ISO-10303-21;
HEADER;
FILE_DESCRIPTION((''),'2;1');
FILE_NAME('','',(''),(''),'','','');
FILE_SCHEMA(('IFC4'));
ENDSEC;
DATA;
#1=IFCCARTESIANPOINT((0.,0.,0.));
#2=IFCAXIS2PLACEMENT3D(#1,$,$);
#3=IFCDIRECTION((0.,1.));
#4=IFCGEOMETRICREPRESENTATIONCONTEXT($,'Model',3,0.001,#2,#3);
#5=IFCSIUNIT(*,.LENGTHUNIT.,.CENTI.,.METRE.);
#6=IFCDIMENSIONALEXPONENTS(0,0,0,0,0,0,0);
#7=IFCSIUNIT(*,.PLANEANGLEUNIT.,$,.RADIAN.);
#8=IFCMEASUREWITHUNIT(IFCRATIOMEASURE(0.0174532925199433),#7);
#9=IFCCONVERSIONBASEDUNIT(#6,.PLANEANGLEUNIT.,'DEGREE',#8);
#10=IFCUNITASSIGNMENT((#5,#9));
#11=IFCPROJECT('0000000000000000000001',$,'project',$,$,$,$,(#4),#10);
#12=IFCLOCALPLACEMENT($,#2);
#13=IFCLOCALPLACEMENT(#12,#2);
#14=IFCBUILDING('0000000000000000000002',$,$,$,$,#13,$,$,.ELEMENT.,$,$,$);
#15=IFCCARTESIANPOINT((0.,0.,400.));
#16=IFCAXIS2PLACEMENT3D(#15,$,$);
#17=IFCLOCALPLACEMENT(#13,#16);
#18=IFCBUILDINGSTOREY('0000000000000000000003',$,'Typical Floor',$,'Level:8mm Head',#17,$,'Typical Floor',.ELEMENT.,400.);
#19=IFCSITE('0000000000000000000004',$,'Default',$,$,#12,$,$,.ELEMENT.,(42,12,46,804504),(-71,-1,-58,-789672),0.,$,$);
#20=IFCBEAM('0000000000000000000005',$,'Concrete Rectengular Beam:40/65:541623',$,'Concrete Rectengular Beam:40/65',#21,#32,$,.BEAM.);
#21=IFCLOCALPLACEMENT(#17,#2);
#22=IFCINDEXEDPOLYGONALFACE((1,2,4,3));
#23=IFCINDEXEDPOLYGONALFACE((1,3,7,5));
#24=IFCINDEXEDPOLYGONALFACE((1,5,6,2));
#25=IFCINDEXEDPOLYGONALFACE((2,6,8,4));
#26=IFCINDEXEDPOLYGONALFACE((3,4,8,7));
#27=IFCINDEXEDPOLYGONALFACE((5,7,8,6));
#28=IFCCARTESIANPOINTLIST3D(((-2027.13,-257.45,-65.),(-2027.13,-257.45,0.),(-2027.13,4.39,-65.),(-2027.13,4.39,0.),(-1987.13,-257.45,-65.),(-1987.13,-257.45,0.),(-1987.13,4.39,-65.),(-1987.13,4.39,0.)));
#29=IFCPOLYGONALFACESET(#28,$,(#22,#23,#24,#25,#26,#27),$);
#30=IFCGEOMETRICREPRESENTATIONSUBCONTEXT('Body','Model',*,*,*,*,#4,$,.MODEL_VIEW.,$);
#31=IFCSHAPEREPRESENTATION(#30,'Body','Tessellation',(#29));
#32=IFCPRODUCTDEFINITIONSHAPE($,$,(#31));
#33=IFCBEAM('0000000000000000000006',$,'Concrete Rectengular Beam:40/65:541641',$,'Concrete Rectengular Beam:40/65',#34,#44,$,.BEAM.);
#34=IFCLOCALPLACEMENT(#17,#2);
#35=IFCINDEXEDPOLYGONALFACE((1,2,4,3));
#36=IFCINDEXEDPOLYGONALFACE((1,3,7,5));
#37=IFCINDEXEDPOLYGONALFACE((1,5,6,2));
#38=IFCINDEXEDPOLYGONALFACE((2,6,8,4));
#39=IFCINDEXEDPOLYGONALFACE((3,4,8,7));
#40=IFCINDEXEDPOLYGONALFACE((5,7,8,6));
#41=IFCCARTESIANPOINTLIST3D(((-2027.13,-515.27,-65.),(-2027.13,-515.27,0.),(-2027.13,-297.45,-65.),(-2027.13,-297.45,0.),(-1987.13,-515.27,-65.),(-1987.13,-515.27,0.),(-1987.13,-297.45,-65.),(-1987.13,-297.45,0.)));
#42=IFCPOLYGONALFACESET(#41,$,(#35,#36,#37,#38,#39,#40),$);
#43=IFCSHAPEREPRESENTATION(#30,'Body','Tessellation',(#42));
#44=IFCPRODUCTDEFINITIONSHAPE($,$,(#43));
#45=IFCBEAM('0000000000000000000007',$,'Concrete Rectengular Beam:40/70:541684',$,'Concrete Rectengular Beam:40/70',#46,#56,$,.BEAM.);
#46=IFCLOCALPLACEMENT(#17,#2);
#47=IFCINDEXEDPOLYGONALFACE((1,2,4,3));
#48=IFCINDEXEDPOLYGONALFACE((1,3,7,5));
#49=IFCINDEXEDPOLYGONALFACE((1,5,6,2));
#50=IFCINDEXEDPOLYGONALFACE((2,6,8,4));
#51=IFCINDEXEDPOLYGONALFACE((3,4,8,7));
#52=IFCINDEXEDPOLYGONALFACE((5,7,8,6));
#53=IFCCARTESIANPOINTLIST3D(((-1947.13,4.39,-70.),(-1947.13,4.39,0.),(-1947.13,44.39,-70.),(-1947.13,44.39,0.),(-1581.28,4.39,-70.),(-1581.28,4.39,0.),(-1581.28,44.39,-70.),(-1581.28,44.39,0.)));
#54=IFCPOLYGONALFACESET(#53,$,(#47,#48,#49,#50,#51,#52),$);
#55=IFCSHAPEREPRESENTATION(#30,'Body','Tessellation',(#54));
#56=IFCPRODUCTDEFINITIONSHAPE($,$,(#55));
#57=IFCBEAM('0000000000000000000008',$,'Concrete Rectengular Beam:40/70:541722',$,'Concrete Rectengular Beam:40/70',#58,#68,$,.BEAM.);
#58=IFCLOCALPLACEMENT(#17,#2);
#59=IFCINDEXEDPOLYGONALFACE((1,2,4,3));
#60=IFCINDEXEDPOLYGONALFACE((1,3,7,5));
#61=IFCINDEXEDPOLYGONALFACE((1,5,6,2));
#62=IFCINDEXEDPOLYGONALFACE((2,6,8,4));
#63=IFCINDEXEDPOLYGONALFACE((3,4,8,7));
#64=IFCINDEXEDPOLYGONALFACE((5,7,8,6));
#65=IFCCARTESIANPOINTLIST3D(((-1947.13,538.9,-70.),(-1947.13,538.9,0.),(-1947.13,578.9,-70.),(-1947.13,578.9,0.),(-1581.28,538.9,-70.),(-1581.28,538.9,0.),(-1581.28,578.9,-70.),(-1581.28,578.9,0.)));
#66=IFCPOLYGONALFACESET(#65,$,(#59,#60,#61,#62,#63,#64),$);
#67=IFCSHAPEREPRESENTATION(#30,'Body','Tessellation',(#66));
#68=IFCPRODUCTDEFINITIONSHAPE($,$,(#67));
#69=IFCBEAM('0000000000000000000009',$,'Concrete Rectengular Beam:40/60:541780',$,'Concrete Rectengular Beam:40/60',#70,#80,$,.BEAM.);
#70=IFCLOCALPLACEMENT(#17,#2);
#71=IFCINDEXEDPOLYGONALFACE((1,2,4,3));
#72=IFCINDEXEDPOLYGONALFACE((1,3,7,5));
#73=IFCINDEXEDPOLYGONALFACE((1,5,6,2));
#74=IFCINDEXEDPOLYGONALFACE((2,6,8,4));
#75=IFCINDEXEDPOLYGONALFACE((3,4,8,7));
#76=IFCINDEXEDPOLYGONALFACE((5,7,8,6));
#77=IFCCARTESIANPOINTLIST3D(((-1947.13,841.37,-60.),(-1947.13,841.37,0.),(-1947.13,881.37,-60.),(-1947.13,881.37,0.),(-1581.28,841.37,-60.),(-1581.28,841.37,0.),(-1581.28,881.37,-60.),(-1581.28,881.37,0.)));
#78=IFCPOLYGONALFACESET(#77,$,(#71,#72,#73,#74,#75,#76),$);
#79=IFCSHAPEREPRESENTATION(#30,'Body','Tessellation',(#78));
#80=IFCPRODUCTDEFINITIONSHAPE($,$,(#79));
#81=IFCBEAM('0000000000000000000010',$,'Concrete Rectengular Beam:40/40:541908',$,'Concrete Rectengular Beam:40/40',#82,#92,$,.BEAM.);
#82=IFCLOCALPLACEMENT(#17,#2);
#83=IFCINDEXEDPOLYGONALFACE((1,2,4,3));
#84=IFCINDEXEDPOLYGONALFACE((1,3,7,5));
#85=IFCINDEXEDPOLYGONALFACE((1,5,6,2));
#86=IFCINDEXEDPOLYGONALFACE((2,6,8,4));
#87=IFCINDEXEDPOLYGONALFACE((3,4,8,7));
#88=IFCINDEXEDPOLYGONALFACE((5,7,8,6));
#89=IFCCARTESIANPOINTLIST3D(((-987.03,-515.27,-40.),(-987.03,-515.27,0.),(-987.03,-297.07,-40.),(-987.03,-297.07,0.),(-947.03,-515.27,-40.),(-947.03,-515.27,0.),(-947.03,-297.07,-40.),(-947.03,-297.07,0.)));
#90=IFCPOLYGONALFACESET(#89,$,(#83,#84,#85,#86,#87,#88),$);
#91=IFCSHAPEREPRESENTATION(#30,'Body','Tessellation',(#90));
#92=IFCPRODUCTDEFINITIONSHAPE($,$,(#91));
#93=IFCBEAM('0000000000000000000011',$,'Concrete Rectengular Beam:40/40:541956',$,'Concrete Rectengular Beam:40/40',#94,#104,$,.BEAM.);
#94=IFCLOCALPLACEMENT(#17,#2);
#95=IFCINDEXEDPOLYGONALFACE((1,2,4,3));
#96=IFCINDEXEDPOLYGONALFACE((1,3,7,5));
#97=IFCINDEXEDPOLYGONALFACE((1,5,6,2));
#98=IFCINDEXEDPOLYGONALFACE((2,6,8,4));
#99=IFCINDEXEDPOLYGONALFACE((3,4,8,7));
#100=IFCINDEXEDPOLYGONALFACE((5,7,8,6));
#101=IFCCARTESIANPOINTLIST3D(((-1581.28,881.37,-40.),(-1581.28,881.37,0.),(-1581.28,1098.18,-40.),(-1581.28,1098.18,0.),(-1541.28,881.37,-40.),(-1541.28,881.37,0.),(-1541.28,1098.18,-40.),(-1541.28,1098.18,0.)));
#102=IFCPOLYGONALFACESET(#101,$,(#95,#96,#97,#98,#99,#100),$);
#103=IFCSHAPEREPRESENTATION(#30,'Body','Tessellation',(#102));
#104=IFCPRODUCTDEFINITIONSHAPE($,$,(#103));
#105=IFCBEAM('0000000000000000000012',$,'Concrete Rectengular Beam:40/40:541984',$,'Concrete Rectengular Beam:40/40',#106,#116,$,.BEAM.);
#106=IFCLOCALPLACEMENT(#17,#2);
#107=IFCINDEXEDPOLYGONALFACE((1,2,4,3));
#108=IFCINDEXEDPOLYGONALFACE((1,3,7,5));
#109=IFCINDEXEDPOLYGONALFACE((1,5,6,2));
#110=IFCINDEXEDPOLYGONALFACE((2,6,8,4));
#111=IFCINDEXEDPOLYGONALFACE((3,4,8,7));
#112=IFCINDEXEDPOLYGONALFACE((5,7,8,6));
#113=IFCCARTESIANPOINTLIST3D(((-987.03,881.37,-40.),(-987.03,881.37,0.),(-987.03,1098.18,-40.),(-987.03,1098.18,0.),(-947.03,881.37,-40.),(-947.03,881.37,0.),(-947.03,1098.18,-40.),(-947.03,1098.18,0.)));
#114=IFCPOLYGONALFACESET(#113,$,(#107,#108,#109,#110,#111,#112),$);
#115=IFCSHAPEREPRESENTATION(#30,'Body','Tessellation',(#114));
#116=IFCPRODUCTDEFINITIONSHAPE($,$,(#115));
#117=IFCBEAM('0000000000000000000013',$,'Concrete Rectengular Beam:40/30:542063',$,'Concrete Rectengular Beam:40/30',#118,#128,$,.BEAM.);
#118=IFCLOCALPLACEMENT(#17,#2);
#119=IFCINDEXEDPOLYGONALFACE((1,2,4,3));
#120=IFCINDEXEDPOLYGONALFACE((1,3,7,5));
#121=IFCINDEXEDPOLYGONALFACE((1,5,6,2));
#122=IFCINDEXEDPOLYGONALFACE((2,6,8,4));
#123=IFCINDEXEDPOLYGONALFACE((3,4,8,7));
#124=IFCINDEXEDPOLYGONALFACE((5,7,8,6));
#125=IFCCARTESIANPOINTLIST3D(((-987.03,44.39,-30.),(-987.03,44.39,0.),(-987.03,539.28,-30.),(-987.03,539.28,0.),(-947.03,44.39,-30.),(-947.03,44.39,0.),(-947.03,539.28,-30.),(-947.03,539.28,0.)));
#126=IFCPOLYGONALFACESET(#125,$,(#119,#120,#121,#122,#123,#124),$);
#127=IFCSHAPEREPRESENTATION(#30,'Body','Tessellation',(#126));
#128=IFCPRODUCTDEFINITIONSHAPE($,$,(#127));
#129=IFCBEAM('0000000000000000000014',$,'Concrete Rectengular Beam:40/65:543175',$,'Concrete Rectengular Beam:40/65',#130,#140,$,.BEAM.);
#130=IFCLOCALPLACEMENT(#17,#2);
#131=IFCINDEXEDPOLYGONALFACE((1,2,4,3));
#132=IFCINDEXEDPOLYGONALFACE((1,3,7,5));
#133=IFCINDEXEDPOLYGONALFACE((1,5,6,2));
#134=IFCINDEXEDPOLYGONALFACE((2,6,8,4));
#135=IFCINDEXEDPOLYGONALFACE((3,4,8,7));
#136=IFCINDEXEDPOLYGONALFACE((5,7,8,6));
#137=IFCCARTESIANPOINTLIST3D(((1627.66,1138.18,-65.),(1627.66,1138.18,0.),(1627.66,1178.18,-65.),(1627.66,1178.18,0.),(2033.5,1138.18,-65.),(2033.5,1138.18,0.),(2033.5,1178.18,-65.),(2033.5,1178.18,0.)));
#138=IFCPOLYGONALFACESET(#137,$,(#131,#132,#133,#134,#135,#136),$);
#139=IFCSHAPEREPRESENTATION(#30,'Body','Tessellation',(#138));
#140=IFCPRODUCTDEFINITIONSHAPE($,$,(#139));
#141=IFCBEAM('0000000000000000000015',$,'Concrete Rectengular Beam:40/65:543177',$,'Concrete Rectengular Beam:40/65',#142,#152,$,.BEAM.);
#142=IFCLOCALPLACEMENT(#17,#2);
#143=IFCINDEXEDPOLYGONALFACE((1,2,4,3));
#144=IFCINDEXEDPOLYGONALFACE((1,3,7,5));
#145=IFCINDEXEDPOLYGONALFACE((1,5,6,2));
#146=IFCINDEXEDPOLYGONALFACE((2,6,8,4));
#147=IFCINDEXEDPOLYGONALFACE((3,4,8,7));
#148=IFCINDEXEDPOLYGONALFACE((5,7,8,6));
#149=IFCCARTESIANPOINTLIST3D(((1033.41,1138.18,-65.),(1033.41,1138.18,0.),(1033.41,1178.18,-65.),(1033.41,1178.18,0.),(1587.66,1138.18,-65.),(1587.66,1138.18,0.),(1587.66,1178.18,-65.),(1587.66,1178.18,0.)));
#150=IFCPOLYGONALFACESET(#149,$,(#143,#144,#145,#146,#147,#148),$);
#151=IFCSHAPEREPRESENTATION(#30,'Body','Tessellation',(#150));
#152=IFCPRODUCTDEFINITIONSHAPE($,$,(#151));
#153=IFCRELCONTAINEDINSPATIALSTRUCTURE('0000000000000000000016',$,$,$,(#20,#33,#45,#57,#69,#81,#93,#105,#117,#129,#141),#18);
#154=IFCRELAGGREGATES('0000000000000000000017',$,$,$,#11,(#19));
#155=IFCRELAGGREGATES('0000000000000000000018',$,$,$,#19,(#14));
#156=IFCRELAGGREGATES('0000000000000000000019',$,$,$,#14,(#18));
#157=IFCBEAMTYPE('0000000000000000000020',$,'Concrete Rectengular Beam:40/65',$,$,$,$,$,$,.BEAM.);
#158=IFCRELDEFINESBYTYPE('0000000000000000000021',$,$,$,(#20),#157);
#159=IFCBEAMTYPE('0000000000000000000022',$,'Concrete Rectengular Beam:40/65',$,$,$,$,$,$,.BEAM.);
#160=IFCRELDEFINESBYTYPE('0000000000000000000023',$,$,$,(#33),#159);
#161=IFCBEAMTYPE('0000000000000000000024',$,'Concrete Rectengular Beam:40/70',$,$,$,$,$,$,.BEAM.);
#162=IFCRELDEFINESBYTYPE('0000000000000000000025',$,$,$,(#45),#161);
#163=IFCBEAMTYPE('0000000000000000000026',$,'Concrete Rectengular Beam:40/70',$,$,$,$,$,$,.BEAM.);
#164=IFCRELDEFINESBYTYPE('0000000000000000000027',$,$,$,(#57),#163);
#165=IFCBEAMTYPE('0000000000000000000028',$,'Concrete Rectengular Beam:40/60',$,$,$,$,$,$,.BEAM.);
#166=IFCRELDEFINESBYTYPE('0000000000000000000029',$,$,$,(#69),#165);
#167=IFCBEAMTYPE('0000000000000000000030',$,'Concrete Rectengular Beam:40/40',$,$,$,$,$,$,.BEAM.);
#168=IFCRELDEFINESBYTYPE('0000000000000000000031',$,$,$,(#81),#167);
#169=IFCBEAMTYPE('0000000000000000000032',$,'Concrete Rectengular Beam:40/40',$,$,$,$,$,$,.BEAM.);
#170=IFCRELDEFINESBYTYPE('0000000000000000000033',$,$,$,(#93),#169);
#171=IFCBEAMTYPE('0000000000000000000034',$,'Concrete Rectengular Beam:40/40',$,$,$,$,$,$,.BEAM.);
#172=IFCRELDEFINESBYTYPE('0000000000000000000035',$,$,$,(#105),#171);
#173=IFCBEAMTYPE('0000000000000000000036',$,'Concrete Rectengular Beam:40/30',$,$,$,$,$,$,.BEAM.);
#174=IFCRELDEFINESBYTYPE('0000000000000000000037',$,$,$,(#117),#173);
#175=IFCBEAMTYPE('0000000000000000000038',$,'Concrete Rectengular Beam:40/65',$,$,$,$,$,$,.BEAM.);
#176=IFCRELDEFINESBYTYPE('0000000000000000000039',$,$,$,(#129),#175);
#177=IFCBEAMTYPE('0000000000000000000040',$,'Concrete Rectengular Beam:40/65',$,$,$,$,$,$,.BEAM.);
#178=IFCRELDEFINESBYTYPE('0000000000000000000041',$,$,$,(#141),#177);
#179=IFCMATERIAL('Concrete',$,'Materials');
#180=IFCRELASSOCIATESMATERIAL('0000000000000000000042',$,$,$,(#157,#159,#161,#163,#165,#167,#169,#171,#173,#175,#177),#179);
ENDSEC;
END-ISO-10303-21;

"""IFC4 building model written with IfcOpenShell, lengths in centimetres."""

from ifc_helpers import new_model, entity, si_unit, converted_unit, direction, frame, origin, place, context, subcontext, project, spatial, indexed_curve, outline, extrude, source, transform, mapped, material, type_object, type_shapes, element, save


model = new_model("IFC4")

# Units and contexts
model_context = context("Model", 3, precision=0.001, world=origin(), true_north=direction((0.0, 1.0)))
body_context = subcontext(model_context, "Body", "Model", "MODEL_VIEW")
ifc_project = project(units=[si_unit("LENGTHUNIT", "METRE", prefix="CENTI"), converted_unit("PLANEANGLEUNIT", "DEGREE", entity("IfcRatioMeasure", 0.0174532925199433), si_unit("PLANEANGLEUNIT", "RADIAN"), dimensions=[0, 0, 0, 0, 0, 0, 0])], contexts=[model_context])

# Site, building, storey
site_placement = place(None, origin())
site = spatial("IfcSite", under=ifc_project, at=site_placement, Name="Default", CompositionType="ELEMENT", RefLatitude=(42, 12, 46, 804504), RefLongitude=(-71, -1, -58, -789672), RefElevation=0.0)
building_placement = place(site_placement, origin())
building = spatial("IfcBuilding", under=site, at=building_placement, CompositionType="ELEMENT")
storey_placement = place(building_placement, frame((0.0, 0.0, 400.0)))
storey = spatial("IfcBuildingStorey", under=building, at=storey_placement, Name="Typical Floor", ObjectType="Level:8mm Head", LongName="Typical Floor", CompositionType="ELEMENT", Elevation=400.0)

# Beams
ifc_material = material(Name="Concrete", Category="Materials")
beam_type_1 = type_object("IfcBeamType", Name="Concrete Rectengular Beam:40/65", PredefinedType="BEAM", material=ifc_material)
shared_shape_1 = source(origin(), body_context, "Body", "SweptSolid", [
    extrude(outline(indexed_curve([(-20.0, -32.5), (20.0, -32.5), (20.0, 32.5), (-20.0, 32.5), (-20.0, -32.5)], self_intersect=False)), frame((-2007.13, 4.39, 367.5), z_axis=(0.0, -1.0, 0.0), x_axis=(-1.0, 0.0, 0.0)), (0.0, 0.0, 1.0), 261.84),
])
type_shapes(beam_type_1, [shared_shape_1])
beam_1_placement = place(storey_placement, frame((0.0, 0.0, -400.0)))
element("IfcBeam", 1, at=beam_1_placement, inside=storey, type_object=beam_type_1, Name="Concrete Rectengular Beam:40/65:541623", ObjectType="Concrete Rectengular Beam:40/65", PredefinedType="BEAM", context=body_context, shape_type="MappedRepresentation", body=[
    mapped(shared_shape_1, transform((0.0, 0.0, 0.0), scale=1.0)),
])
beam_type_2 = type_object("IfcBeamType", Name="Concrete Rectengular Beam:40/65", PredefinedType="BEAM", material=ifc_material)
shared_shape_2 = source(origin(), body_context, "Body", "SweptSolid", [
    extrude(outline(indexed_curve([(-20.0, -32.5), (20.0, -32.5), (20.0, 32.5), (-20.0, 32.5), (-20.0, -32.5)], self_intersect=False)), frame((-2007.13, -297.45, 367.5), z_axis=(0.0, -1.0, 0.0), x_axis=(-1.0, 0.0, 0.0)), (0.0, 0.0, 1.0), 217.82),
])
type_shapes(beam_type_2, [shared_shape_2])
beam_2_placement = place(storey_placement, frame((0.0, 0.0, -400.0)))
element("IfcBeam", 2, at=beam_2_placement, inside=storey, type_object=beam_type_2, Name="Concrete Rectengular Beam:40/65:541641", ObjectType="Concrete Rectengular Beam:40/65", PredefinedType="BEAM", context=body_context, shape_type="MappedRepresentation", body=[
    mapped(shared_shape_2, transform((0.0, 0.0, 0.0), scale=1.0)),
])
beam_type_3 = type_object("IfcBeamType", Name="Concrete Rectengular Beam:40/70", PredefinedType="BEAM", material=ifc_material)
shared_shape_3 = source(origin(), body_context, "Body", "SweptSolid", [
    extrude(outline(indexed_curve([(-35.0, -20.0), (35.0, -20.0), (35.0, 20.0), (-35.0, 20.0), (-35.0, -20.0)], self_intersect=False)), frame((-1947.13, 24.39, 365.0), z_axis=(1.0, 0.0, 0.0), x_axis=(0.0, 0.0, -1.0)), (0.0, 0.0, 1.0), 365.84),
])
type_shapes(beam_type_3, [shared_shape_3])
beam_3_placement = place(storey_placement, frame((0.0, 0.0, -400.0)))
element("IfcBeam", 3, at=beam_3_placement, inside=storey, type_object=beam_type_3, Name="Concrete Rectengular Beam:40/70:541684", ObjectType="Concrete Rectengular Beam:40/70", PredefinedType="BEAM", context=body_context, shape_type="MappedRepresentation", body=[
    mapped(shared_shape_3, transform((0.0, 0.0, 0.0), scale=1.0)),
])
beam_type_4 = type_object("IfcBeamType", Name="Concrete Rectengular Beam:40/70", PredefinedType="BEAM", material=ifc_material)
shared_shape_4 = source(origin(), body_context, "Body", "SweptSolid", [
    extrude(outline(indexed_curve([(-35.0, -20.0), (35.0, -20.0), (35.0, 20.0), (-35.0, 20.0), (-35.0, -20.0)], self_intersect=False)), frame((-1947.13, 558.9, 365.0), z_axis=(1.0, 0.0, 0.0), x_axis=(0.0, 0.0, -1.0)), (0.0, 0.0, 1.0), 365.84),
])
type_shapes(beam_type_4, [shared_shape_4])
beam_4_placement = place(storey_placement, frame((0.0, 0.0, -400.0)))
element("IfcBeam", 4, at=beam_4_placement, inside=storey, type_object=beam_type_4, Name="Concrete Rectengular Beam:40/70:541722", ObjectType="Concrete Rectengular Beam:40/70", PredefinedType="BEAM", context=body_context, shape_type="MappedRepresentation", body=[
    mapped(shared_shape_4, transform((0.0, 0.0, 0.0), scale=1.0)),
])
beam_type_5 = type_object("IfcBeamType", Name="Concrete Rectengular Beam:40/60", PredefinedType="BEAM", material=ifc_material)
shared_shape_5 = source(origin(), body_context, "Body", "SweptSolid", [
    extrude(outline(indexed_curve([(-30.0, -20.0), (30.0, -20.0), (30.0, 20.0), (-30.0, 20.0), (-30.0, -20.0)], self_intersect=False)), frame((-1947.13, 861.37, 370.0), z_axis=(1.0, 0.0, 0.0), x_axis=(0.0, 0.0, -1.0)), (0.0, 0.0, 1.0), 365.84),
])
type_shapes(beam_type_5, [shared_shape_5])
beam_5_placement = place(storey_placement, frame((0.0, 0.0, -400.0)))
element("IfcBeam", 5, at=beam_5_placement, inside=storey, type_object=beam_type_5, Name="Concrete Rectengular Beam:40/60:541780", ObjectType="Concrete Rectengular Beam:40/60", PredefinedType="BEAM", context=body_context, shape_type="MappedRepresentation", body=[
    mapped(shared_shape_5, transform((0.0, 0.0, 0.0), scale=1.0)),
])
beam_type_6 = type_object("IfcBeamType", Name="Concrete Rectengular Beam:40/40", PredefinedType="BEAM", material=ifc_material)
shared_shape_6 = source(origin(), body_context, "Body", "SweptSolid", [
    extrude(outline(indexed_curve([(-20.0, -20.0), (20.0, -20.0), (20.0, 20.0), (-20.0, 20.0), (-20.0, -20.0)], self_intersect=False)), frame((-967.03, -515.27, 380.0), z_axis=(0.0, 1.0, 0.0), x_axis=(-1.0, 0.0, 0.0)), (0.0, 0.0, 1.0), 218.21),
])
type_shapes(beam_type_6, [shared_shape_6])
beam_6_placement = place(storey_placement, frame((0.0, 0.0, -400.0)))
element("IfcBeam", 6, at=beam_6_placement, inside=storey, type_object=beam_type_6, Name="Concrete Rectengular Beam:40/40:541908", ObjectType="Concrete Rectengular Beam:40/40", PredefinedType="BEAM", context=body_context, shape_type="MappedRepresentation", body=[
    mapped(shared_shape_6, transform((0.0, 0.0, 0.0), scale=1.0)),
])
beam_type_7 = type_object("IfcBeamType", Name="Concrete Rectengular Beam:40/40", PredefinedType="BEAM", material=ifc_material)
shared_shape_7 = source(origin(), body_context, "Body", "SweptSolid", [
    extrude(outline(indexed_curve([(-20.0, -20.0), (20.0, -20.0), (20.0, 20.0), (-20.0, 20.0), (-20.0, -20.0)], self_intersect=False)), frame((-1561.28, 1098.18, 380.0), z_axis=(0.0, -1.0, 0.0), x_axis=(-1.0, 0.0, 0.0)), (0.0, 0.0, 1.0), 216.81),
])
type_shapes(beam_type_7, [shared_shape_7])
beam_7_placement = place(storey_placement, frame((0.0, 0.0, -400.0)))
element("IfcBeam", 7, at=beam_7_placement, inside=storey, type_object=beam_type_7, Name="Concrete Rectengular Beam:40/40:541956", ObjectType="Concrete Rectengular Beam:40/40", PredefinedType="BEAM", context=body_context, shape_type="MappedRepresentation", body=[
    mapped(shared_shape_7, transform((0.0, 0.0, 0.0), scale=1.0)),
])
beam_type_8 = type_object("IfcBeamType", Name="Concrete Rectengular Beam:40/40", PredefinedType="BEAM", material=ifc_material)
shared_shape_8 = source(origin(), body_context, "Body", "SweptSolid", [
    extrude(outline(indexed_curve([(-20.0, -20.0), (20.0, -20.0), (20.0, 20.0), (-20.0, 20.0), (-20.0, -20.0)], self_intersect=False)), frame((-967.03, 1098.18, 380.0), z_axis=(0.0, -1.0, 0.0), x_axis=(-1.0, 0.0, 0.0)), (0.0, 0.0, 1.0), 216.81),
])
type_shapes(beam_type_8, [shared_shape_8])
beam_8_placement = place(storey_placement, frame((0.0, 0.0, -400.0)))
element("IfcBeam", 8, at=beam_8_placement, inside=storey, type_object=beam_type_8, Name="Concrete Rectengular Beam:40/40:541984", ObjectType="Concrete Rectengular Beam:40/40", PredefinedType="BEAM", context=body_context, shape_type="MappedRepresentation", body=[
    mapped(shared_shape_8, transform((0.0, 0.0, 0.0), scale=1.0)),
])
beam_type_9 = type_object("IfcBeamType", Name="Concrete Rectengular Beam:40/30", PredefinedType="BEAM", material=ifc_material)
shared_shape_9 = source(origin(), body_context, "Body", "SweptSolid", [
    extrude(outline(indexed_curve([(-20.0, -15.0), (20.0, -15.0), (20.0, 15.0), (-20.0, 15.0), (-20.0, -15.0)], self_intersect=False)), frame((-967.03, 539.28, 385.0), z_axis=(0.0, -1.0, 0.0), x_axis=(-1.0, 0.0, 0.0)), (0.0, 0.0, 1.0), 494.89),
])
type_shapes(beam_type_9, [shared_shape_9])
beam_9_placement = place(storey_placement, frame((0.0, 0.0, -400.0)))
element("IfcBeam", 9, at=beam_9_placement, inside=storey, type_object=beam_type_9, Name="Concrete Rectengular Beam:40/30:542063", ObjectType="Concrete Rectengular Beam:40/30", PredefinedType="BEAM", context=body_context, shape_type="MappedRepresentation", body=[
    mapped(shared_shape_9, transform((0.0, 0.0, 0.0), scale=1.0)),
])
beam_type_10 = type_object("IfcBeamType", Name="Concrete Rectengular Beam:40/65", PredefinedType="BEAM", material=ifc_material)
shared_shape_10 = source(origin(), body_context, "Body", "SweptSolid", [
    extrude(outline(indexed_curve([(-32.5, -20.0), (32.5, -20.0), (32.5, 20.0), (-32.5, 20.0), (-32.5, -20.0)], self_intersect=False)), frame((1627.66, 1158.18, 367.5), z_axis=(1.0, 0.0, 0.0), x_axis=(0.0, 0.0, -1.0)), (0.0, 0.0, 1.0), 405.84),
])
type_shapes(beam_type_10, [shared_shape_10])
beam_10_placement = place(storey_placement, frame((0.0, 0.0, -400.0)))
element("IfcBeam", 10, at=beam_10_placement, inside=storey, type_object=beam_type_10, Name="Concrete Rectengular Beam:40/65:543175", ObjectType="Concrete Rectengular Beam:40/65", PredefinedType="BEAM", context=body_context, shape_type="MappedRepresentation", body=[
    mapped(shared_shape_10, transform((0.0, 0.0, 0.0), scale=1.0)),
])
beam_type_11 = type_object("IfcBeamType", Name="Concrete Rectengular Beam:40/65", PredefinedType="BEAM", material=ifc_material)
shared_shape_11 = source(origin(), body_context, "Body", "SweptSolid", [
    extrude(outline(indexed_curve([(-32.5, -20.0), (32.5, -20.0), (32.5, 20.0), (-32.5, 20.0), (-32.5, -20.0)], self_intersect=False)), frame((1587.66, 1158.18, 367.5), z_axis=(-1.0, 0.0, 0.0), x_axis=(0.0, 0.0, -1.0)), (0.0, 0.0, 1.0), 554.25),
])
type_shapes(beam_type_11, [shared_shape_11])
beam_11_placement = place(storey_placement, frame((0.0, 0.0, -400.0)))
element("IfcBeam", 11, at=beam_11_placement, inside=storey, type_object=beam_type_11, Name="Concrete Rectengular Beam:40/65:543177", ObjectType="Concrete Rectengular Beam:40/65", PredefinedType="BEAM", context=body_context, shape_type="MappedRepresentation", body=[
    mapped(shared_shape_11, transform((0.0, 0.0, 0.0), scale=1.0)),
])

save(model, "model.ifc")
